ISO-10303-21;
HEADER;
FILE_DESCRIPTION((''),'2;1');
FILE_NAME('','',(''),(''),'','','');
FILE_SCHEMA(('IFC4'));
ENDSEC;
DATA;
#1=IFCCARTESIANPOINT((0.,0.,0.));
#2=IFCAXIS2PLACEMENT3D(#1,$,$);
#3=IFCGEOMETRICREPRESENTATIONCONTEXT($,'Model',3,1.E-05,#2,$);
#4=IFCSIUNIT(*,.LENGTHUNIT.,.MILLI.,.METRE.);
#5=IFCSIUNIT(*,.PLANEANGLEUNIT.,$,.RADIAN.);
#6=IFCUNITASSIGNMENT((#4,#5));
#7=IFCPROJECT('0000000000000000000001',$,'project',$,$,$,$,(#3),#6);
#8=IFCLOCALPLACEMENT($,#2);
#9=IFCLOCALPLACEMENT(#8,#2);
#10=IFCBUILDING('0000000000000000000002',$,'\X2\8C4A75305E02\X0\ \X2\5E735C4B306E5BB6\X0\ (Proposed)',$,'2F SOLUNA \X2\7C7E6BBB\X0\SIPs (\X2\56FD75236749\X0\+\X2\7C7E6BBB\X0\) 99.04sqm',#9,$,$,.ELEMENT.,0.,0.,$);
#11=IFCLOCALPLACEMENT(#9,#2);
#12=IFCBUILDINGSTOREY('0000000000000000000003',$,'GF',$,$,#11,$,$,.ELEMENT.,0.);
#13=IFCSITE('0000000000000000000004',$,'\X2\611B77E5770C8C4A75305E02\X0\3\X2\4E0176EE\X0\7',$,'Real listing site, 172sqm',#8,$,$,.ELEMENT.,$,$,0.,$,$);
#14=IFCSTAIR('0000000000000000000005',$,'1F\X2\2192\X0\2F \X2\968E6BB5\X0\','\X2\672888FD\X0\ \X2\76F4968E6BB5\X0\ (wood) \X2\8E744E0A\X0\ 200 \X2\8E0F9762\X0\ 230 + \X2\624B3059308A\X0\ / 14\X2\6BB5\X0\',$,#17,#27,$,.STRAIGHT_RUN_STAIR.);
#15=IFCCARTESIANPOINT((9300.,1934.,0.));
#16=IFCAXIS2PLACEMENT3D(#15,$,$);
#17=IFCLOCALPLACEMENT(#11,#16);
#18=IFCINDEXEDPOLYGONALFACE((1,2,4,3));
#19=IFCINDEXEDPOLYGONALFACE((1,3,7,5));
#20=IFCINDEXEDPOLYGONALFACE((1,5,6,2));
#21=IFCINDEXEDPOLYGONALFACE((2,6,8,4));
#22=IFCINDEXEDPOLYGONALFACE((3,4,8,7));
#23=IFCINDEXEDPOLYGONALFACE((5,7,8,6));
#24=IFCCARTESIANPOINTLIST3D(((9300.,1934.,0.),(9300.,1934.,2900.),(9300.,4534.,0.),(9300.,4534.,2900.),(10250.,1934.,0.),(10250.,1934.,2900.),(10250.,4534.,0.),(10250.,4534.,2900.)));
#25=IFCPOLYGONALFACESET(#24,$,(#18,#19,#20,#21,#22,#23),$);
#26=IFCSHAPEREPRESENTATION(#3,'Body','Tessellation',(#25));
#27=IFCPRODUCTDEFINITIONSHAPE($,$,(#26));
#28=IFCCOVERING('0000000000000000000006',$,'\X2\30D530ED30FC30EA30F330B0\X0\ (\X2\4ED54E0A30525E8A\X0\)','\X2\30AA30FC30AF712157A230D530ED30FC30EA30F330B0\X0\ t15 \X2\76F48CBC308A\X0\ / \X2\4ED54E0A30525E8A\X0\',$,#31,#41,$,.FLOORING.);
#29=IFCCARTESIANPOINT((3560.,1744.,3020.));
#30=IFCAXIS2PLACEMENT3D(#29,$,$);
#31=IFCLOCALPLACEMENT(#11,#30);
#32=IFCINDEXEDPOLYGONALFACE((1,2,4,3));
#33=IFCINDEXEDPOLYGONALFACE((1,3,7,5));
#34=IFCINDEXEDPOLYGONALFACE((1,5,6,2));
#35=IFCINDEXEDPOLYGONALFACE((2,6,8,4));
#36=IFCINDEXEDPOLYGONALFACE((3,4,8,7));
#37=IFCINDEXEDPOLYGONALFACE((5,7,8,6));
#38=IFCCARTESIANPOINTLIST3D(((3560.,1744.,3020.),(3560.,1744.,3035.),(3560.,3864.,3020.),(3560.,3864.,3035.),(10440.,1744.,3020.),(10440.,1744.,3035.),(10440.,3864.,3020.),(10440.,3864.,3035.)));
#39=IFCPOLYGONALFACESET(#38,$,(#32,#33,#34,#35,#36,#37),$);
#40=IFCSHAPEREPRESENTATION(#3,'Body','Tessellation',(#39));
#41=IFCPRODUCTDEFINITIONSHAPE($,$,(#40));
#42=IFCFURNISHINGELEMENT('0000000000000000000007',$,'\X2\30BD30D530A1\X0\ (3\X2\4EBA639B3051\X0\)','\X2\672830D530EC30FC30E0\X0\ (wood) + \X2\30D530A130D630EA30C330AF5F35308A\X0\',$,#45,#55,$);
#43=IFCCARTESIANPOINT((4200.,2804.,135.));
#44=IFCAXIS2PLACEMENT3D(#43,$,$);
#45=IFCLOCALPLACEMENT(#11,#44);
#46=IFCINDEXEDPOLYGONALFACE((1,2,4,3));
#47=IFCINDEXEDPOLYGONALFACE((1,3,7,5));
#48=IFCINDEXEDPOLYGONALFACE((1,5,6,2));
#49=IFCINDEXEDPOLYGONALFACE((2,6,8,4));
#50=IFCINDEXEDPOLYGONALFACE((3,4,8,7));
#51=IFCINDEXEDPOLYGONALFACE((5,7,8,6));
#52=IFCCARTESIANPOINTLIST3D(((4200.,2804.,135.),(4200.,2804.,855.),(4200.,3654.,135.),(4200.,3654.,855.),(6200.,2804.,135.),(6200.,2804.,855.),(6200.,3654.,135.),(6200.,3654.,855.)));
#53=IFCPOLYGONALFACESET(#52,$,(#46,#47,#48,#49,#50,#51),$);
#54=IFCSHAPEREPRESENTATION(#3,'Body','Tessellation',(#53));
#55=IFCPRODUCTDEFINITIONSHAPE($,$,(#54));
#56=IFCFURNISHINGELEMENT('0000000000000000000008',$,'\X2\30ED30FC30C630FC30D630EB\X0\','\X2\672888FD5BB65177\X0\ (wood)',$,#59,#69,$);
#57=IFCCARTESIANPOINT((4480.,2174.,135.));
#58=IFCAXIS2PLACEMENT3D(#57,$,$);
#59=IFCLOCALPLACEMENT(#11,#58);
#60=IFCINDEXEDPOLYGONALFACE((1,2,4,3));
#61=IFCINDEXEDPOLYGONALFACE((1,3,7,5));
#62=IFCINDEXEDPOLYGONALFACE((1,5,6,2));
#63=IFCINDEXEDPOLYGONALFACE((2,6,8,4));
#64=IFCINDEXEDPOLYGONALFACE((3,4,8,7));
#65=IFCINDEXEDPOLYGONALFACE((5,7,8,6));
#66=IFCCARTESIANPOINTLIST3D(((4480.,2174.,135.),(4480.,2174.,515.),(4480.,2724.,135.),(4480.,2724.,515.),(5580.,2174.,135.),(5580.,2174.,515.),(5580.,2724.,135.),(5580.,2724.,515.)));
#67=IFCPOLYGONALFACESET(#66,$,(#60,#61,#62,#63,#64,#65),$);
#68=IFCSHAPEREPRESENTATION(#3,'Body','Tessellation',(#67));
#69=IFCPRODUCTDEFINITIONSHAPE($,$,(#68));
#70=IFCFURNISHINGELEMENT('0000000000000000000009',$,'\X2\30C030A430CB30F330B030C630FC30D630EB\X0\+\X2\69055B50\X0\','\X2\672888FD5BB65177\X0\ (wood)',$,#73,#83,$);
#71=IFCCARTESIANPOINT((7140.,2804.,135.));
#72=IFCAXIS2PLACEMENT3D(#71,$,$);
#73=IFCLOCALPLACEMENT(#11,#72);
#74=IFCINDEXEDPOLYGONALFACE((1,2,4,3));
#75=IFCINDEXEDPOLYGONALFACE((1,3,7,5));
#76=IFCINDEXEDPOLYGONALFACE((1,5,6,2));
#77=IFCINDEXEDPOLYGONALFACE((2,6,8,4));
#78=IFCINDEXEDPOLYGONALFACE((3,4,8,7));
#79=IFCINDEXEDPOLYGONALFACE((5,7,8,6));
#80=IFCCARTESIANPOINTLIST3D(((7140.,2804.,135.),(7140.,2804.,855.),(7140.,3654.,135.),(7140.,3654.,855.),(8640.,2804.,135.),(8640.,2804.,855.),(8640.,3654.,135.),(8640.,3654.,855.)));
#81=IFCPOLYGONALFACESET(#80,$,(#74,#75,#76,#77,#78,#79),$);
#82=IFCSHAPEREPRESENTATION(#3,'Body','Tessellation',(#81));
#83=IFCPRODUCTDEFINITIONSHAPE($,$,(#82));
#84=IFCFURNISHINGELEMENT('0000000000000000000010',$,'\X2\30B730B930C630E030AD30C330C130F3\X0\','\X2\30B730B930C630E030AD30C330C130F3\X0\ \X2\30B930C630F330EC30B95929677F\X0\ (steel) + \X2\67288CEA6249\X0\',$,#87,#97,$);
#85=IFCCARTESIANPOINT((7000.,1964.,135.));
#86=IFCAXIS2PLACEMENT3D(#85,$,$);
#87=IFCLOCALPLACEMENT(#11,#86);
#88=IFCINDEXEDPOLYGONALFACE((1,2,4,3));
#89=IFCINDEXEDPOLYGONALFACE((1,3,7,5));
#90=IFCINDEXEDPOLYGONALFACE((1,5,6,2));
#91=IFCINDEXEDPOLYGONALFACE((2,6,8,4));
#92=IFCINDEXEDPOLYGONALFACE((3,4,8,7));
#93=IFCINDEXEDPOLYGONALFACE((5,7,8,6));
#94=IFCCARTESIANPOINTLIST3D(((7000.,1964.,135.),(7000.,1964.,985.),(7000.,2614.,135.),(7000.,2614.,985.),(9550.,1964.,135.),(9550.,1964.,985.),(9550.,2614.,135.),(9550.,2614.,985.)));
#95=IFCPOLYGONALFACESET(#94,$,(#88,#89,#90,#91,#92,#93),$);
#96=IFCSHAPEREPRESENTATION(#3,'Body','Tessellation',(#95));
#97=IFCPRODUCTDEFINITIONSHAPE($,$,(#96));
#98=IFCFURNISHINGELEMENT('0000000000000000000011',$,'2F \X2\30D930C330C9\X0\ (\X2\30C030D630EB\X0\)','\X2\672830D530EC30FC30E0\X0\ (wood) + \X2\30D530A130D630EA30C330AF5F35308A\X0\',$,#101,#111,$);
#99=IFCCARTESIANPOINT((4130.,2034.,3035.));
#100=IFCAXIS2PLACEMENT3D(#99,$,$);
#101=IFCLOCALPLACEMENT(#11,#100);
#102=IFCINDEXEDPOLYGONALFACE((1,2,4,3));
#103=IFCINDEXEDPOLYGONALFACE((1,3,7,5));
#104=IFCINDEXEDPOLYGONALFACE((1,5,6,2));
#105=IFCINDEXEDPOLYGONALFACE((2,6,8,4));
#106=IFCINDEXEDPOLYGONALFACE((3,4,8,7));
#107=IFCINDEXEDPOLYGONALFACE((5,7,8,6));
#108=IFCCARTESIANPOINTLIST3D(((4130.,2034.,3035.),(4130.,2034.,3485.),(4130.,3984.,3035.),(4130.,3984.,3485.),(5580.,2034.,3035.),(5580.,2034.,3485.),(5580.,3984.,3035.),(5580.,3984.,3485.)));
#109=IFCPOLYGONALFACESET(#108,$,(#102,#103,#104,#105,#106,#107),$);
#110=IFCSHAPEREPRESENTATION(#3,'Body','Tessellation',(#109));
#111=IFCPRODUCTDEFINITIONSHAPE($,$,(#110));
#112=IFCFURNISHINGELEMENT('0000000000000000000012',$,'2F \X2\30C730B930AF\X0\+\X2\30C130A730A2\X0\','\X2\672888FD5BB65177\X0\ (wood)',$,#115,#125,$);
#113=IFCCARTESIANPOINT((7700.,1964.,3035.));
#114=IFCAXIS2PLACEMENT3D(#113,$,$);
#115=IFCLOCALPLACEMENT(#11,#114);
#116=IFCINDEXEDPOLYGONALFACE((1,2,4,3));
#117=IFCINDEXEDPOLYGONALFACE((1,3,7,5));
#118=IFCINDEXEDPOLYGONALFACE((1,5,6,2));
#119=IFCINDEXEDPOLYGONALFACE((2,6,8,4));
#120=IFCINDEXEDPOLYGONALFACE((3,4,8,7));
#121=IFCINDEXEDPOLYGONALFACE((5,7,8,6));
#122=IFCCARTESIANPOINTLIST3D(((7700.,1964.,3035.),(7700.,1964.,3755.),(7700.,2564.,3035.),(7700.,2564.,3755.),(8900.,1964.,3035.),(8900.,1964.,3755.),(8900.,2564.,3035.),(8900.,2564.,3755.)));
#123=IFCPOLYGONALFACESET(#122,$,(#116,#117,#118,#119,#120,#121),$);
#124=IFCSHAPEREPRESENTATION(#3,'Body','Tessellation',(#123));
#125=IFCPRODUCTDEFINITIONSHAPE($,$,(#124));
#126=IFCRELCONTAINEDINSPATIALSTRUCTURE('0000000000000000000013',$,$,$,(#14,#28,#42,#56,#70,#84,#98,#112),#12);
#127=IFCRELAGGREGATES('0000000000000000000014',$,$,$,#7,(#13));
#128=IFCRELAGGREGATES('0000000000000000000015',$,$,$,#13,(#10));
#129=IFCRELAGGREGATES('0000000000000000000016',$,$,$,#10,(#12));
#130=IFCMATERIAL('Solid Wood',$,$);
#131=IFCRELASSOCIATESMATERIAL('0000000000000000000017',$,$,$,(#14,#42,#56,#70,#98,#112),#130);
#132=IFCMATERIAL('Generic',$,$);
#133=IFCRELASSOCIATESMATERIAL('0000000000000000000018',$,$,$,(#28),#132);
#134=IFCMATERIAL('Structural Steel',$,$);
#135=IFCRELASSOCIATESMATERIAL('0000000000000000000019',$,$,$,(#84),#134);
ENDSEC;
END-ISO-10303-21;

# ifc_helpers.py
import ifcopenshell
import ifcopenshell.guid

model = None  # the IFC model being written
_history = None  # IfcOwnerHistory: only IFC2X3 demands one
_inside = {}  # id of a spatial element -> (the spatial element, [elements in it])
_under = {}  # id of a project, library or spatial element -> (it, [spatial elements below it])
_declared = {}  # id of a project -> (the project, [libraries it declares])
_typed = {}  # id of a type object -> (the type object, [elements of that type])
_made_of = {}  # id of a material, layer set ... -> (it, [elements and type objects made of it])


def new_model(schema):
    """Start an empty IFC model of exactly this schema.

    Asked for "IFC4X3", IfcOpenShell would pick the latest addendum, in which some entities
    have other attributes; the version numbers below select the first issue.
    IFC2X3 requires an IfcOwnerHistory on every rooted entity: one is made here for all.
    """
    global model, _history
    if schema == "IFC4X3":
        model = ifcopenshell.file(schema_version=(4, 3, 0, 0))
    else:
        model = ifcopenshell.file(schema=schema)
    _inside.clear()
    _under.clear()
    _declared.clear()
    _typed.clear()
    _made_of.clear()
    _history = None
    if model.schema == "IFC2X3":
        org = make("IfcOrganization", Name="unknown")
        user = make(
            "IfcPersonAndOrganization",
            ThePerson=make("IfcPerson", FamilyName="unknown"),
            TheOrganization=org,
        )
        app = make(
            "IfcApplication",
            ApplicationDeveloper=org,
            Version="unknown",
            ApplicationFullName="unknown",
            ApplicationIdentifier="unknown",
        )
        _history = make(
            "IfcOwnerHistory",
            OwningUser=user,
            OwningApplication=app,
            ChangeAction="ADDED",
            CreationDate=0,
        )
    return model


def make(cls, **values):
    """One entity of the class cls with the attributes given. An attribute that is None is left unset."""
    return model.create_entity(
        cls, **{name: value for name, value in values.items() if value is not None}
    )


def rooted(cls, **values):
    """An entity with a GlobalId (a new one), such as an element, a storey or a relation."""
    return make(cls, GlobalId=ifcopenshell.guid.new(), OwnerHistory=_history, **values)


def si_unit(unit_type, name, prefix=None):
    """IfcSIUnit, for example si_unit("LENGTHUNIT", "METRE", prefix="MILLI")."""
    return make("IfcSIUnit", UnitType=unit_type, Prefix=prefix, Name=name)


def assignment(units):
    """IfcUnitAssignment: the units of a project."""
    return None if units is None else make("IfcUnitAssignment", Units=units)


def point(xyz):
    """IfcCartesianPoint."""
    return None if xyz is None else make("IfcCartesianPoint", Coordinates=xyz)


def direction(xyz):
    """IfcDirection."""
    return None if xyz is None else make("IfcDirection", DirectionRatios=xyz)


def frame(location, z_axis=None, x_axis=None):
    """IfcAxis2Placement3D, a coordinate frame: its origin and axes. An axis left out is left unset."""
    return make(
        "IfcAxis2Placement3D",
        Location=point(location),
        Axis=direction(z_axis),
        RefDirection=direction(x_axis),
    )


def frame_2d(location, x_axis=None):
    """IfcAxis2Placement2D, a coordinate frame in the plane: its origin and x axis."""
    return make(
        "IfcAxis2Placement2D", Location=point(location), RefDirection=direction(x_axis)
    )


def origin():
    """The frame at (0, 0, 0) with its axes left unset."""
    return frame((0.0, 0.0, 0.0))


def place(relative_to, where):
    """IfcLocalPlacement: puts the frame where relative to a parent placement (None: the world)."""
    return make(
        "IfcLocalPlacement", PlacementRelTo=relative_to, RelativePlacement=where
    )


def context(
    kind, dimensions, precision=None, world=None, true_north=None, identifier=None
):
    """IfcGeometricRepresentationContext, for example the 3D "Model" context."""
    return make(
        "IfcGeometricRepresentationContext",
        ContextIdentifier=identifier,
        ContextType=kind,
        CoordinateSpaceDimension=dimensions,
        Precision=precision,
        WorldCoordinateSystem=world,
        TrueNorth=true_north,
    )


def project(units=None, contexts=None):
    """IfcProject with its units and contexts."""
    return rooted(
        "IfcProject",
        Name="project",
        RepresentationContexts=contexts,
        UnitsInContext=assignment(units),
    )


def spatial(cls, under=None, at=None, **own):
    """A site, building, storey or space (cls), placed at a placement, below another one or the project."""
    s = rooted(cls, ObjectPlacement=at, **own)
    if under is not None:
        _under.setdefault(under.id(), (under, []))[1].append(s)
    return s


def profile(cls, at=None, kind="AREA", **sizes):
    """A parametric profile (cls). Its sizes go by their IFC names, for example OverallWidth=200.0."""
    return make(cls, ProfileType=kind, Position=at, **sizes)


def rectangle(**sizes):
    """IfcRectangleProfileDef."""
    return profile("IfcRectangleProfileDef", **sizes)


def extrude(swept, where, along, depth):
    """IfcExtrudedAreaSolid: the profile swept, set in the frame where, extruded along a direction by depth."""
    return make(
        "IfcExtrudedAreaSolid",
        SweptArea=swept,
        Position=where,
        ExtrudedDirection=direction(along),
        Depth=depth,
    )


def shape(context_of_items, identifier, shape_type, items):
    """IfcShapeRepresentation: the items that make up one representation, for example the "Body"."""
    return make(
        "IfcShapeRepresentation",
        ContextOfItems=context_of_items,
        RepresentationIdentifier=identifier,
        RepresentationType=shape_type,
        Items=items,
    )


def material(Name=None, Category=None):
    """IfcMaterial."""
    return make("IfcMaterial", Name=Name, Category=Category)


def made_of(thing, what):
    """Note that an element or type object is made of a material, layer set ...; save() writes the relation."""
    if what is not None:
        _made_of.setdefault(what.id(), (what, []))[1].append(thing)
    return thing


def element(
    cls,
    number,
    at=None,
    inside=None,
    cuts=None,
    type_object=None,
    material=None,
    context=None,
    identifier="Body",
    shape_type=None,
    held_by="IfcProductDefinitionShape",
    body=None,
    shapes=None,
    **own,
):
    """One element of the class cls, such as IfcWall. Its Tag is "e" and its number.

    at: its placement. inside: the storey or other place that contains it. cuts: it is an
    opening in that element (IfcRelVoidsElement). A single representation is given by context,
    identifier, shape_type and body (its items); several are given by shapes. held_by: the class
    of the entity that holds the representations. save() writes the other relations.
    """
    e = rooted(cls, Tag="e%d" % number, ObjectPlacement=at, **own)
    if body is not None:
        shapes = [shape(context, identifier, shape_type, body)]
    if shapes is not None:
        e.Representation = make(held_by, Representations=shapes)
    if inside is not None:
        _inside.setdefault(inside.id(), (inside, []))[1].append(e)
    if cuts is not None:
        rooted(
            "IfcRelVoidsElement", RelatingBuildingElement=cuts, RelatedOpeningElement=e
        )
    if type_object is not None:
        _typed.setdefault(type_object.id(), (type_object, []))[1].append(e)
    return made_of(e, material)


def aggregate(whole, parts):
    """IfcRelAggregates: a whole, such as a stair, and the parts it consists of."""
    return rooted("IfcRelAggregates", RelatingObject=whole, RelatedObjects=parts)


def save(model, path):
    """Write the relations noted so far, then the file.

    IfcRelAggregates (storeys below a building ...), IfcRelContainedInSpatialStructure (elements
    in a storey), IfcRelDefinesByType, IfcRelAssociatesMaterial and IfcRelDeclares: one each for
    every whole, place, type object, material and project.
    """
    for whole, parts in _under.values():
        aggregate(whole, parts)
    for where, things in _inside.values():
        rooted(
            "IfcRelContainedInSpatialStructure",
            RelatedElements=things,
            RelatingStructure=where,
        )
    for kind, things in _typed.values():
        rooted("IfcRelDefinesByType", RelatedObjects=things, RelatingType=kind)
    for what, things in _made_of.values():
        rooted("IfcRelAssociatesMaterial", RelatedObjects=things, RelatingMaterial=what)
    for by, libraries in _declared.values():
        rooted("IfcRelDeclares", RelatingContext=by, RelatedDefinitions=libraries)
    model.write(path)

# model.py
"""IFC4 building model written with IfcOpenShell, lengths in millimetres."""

from ifc_helpers import new_model, si_unit, frame, frame_2d, origin, place, context, project, spatial, rectangle, extrude, material, element, save


model = new_model("IFC4")

# Units and contexts
model_context = context("Model", 3, precision=1e-05, world=origin())
ifc_project = project(units=[si_unit("LENGTHUNIT", "METRE", prefix="MILLI"), si_unit("PLANEANGLEUNIT", "RADIAN")], contexts=[model_context])

# Site, building, storey
site_placement = place(None, origin())
site = spatial("IfcSite", under=ifc_project, at=site_placement, Name="愛知県豊田市3丁目7", ObjectType="Real listing site, 172sqm", CompositionType="ELEMENT", RefElevation=0.0)
building_placement = place(site_placement, origin())
building = spatial("IfcBuilding", under=site, at=building_placement, Name="豊田市 平屋の家 (Proposed)", ObjectType="2F SOLUNA 籾殻SIPs (国産杉+籾殻) 99.04sqm", CompositionType="ELEMENT", ElevationOfRefHeight=0.0, ElevationOfTerrain=0.0)
storey_placement = place(building_placement, origin())
storey = spatial("IfcBuildingStorey", under=building, at=storey_placement, Name="GF", CompositionType="ELEMENT", Elevation=0.0)

# Shared definitions
ifc_material_1 = material(Name="Solid Wood")

# Shared definitions
ifc_material_2 = material(Name="Generic")

# Stair
stair_placement = place(storey_placement, frame((9300.0, 1934.0, 0.0)))
element("IfcStair", 1, at=stair_placement, inside=storey, material=ifc_material_1, Name="1F→2F 階段", Description="木製 直階段 (wood) 蹴上 200 踏面 230 + 手すり / 14段", PredefinedType="STRAIGHT_RUN_STAIR", context=model_context, shape_type="SweptSolid", body=[
    extrude(rectangle(XDim=950.0, YDim=2600.0, at=frame_2d((475.0, 1300.0))), frame((9300.0, 1934.0, 0.0)), (0.0, 0.0, 1.0), 2900.0),
])

# Covering
covering_placement = place(storey_placement, frame((3560.0, 1744.0, 3020.0)))
element("IfcCovering", 2, at=covering_placement, inside=storey, material=ifc_material_2, Name="フローリング (仕上げ床)", Description="オーク無垢フローリング t15 直貼り / 仕上げ床", PredefinedType="FLOORING", context=model_context, shape_type="SweptSolid", body=[
    extrude(rectangle(XDim=6880.0, YDim=2120.0, at=frame_2d((3440.0, 1060.0))), frame((3560.0, 1744.0, 3020.0)), (0.0, 0.0, 1.0), 15.0),
])

# Furnishing elements
furnishing_1_placement = place(storey_placement, frame((4200.0, 2804.0, 135.0)))
element("IfcFurnishingElement", 3, at=furnishing_1_placement, inside=storey, material=ifc_material_1, Name="ソファ (3人掛け)", Description="木フレーム (wood) + ファブリック張り", context=model_context, shape_type="SweptSolid", body=[
    extrude(rectangle(XDim=2000.0, YDim=850.0, at=frame_2d((1000.0, 425.0))), frame((4200.0, 2804.0, 135.0)), (0.0, 0.0, 1.0), 720.0),
])
furnishing_2_placement = place(storey_placement, frame((4480.0, 2174.0, 135.0)))
element("IfcFurnishingElement", 4, at=furnishing_2_placement, inside=storey, material=ifc_material_1, Name="ローテーブル", Description="木製家具 (wood)", context=model_context, shape_type="SweptSolid", body=[
    extrude(rectangle(XDim=1100.0, YDim=550.0, at=frame_2d((550.0, 275.0))), frame((4480.0, 2174.0, 135.0)), (0.0, 0.0, 1.0), 380.0),
])
furnishing_3_placement = place(storey_placement, frame((7140.0, 2804.0, 135.0)))
element("IfcFurnishingElement", 5, at=furnishing_3_placement, inside=storey, material=ifc_material_1, Name="ダイニングテーブル+椅子", Description="木製家具 (wood)", context=model_context, shape_type="SweptSolid", body=[
    extrude(rectangle(XDim=1500.0, YDim=850.0, at=frame_2d((750.0, 425.0))), frame((7140.0, 2804.0, 135.0)), (0.0, 0.0, 1.0), 720.0),
])
ifc_material_3 = material(Name="Structural Steel")
furnishing_4_placement = place(storey_placement, frame((7000.0, 1964.0, 135.0)))
element("IfcFurnishingElement", 6, at=furnishing_4_placement, inside=storey, material=ifc_material_3, Name="システムキッチン", Description="システムキッチン ステンレス天板 (steel) + 木質扉", context=model_context, shape_type="SweptSolid", body=[
    extrude(rectangle(XDim=2550.0, YDim=650.0, at=frame_2d((1275.0, 325.0))), frame((7000.0, 1964.0, 135.0)), (0.0, 0.0, 1.0), 850.0),
])
furnishing_5_placement = place(storey_placement, frame((4130.0, 2034.0, 3035.0)))
element("IfcFurnishingElement", 7, at=furnishing_5_placement, inside=storey, material=ifc_material_1, Name="2F ベッド (ダブル)", Description="木フレーム (wood) + ファブリック張り", context=model_context, shape_type="SweptSolid", body=[
    extrude(rectangle(XDim=1450.0, YDim=1950.0, at=frame_2d((725.0, 975.0))), frame((4130.0, 2034.0, 3035.0)), (0.0, 0.0, 1.0), 450.0),
])
furnishing_6_placement = place(storey_placement, frame((7700.0, 1964.0, 3035.0)))
element("IfcFurnishingElement", 8, at=furnishing_6_placement, inside=storey, material=ifc_material_1, Name="2F デスク+チェア", Description="木製家具 (wood)", context=model_context, shape_type="SweptSolid", body=[
    extrude(rectangle(XDim=1200.0, YDim=600.0, at=frame_2d((600.0, 300.0))), frame((7700.0, 1964.0, 3035.0)), (0.0, 0.0, 1.0), 720.0),
])

save(model, "model.ifc")
